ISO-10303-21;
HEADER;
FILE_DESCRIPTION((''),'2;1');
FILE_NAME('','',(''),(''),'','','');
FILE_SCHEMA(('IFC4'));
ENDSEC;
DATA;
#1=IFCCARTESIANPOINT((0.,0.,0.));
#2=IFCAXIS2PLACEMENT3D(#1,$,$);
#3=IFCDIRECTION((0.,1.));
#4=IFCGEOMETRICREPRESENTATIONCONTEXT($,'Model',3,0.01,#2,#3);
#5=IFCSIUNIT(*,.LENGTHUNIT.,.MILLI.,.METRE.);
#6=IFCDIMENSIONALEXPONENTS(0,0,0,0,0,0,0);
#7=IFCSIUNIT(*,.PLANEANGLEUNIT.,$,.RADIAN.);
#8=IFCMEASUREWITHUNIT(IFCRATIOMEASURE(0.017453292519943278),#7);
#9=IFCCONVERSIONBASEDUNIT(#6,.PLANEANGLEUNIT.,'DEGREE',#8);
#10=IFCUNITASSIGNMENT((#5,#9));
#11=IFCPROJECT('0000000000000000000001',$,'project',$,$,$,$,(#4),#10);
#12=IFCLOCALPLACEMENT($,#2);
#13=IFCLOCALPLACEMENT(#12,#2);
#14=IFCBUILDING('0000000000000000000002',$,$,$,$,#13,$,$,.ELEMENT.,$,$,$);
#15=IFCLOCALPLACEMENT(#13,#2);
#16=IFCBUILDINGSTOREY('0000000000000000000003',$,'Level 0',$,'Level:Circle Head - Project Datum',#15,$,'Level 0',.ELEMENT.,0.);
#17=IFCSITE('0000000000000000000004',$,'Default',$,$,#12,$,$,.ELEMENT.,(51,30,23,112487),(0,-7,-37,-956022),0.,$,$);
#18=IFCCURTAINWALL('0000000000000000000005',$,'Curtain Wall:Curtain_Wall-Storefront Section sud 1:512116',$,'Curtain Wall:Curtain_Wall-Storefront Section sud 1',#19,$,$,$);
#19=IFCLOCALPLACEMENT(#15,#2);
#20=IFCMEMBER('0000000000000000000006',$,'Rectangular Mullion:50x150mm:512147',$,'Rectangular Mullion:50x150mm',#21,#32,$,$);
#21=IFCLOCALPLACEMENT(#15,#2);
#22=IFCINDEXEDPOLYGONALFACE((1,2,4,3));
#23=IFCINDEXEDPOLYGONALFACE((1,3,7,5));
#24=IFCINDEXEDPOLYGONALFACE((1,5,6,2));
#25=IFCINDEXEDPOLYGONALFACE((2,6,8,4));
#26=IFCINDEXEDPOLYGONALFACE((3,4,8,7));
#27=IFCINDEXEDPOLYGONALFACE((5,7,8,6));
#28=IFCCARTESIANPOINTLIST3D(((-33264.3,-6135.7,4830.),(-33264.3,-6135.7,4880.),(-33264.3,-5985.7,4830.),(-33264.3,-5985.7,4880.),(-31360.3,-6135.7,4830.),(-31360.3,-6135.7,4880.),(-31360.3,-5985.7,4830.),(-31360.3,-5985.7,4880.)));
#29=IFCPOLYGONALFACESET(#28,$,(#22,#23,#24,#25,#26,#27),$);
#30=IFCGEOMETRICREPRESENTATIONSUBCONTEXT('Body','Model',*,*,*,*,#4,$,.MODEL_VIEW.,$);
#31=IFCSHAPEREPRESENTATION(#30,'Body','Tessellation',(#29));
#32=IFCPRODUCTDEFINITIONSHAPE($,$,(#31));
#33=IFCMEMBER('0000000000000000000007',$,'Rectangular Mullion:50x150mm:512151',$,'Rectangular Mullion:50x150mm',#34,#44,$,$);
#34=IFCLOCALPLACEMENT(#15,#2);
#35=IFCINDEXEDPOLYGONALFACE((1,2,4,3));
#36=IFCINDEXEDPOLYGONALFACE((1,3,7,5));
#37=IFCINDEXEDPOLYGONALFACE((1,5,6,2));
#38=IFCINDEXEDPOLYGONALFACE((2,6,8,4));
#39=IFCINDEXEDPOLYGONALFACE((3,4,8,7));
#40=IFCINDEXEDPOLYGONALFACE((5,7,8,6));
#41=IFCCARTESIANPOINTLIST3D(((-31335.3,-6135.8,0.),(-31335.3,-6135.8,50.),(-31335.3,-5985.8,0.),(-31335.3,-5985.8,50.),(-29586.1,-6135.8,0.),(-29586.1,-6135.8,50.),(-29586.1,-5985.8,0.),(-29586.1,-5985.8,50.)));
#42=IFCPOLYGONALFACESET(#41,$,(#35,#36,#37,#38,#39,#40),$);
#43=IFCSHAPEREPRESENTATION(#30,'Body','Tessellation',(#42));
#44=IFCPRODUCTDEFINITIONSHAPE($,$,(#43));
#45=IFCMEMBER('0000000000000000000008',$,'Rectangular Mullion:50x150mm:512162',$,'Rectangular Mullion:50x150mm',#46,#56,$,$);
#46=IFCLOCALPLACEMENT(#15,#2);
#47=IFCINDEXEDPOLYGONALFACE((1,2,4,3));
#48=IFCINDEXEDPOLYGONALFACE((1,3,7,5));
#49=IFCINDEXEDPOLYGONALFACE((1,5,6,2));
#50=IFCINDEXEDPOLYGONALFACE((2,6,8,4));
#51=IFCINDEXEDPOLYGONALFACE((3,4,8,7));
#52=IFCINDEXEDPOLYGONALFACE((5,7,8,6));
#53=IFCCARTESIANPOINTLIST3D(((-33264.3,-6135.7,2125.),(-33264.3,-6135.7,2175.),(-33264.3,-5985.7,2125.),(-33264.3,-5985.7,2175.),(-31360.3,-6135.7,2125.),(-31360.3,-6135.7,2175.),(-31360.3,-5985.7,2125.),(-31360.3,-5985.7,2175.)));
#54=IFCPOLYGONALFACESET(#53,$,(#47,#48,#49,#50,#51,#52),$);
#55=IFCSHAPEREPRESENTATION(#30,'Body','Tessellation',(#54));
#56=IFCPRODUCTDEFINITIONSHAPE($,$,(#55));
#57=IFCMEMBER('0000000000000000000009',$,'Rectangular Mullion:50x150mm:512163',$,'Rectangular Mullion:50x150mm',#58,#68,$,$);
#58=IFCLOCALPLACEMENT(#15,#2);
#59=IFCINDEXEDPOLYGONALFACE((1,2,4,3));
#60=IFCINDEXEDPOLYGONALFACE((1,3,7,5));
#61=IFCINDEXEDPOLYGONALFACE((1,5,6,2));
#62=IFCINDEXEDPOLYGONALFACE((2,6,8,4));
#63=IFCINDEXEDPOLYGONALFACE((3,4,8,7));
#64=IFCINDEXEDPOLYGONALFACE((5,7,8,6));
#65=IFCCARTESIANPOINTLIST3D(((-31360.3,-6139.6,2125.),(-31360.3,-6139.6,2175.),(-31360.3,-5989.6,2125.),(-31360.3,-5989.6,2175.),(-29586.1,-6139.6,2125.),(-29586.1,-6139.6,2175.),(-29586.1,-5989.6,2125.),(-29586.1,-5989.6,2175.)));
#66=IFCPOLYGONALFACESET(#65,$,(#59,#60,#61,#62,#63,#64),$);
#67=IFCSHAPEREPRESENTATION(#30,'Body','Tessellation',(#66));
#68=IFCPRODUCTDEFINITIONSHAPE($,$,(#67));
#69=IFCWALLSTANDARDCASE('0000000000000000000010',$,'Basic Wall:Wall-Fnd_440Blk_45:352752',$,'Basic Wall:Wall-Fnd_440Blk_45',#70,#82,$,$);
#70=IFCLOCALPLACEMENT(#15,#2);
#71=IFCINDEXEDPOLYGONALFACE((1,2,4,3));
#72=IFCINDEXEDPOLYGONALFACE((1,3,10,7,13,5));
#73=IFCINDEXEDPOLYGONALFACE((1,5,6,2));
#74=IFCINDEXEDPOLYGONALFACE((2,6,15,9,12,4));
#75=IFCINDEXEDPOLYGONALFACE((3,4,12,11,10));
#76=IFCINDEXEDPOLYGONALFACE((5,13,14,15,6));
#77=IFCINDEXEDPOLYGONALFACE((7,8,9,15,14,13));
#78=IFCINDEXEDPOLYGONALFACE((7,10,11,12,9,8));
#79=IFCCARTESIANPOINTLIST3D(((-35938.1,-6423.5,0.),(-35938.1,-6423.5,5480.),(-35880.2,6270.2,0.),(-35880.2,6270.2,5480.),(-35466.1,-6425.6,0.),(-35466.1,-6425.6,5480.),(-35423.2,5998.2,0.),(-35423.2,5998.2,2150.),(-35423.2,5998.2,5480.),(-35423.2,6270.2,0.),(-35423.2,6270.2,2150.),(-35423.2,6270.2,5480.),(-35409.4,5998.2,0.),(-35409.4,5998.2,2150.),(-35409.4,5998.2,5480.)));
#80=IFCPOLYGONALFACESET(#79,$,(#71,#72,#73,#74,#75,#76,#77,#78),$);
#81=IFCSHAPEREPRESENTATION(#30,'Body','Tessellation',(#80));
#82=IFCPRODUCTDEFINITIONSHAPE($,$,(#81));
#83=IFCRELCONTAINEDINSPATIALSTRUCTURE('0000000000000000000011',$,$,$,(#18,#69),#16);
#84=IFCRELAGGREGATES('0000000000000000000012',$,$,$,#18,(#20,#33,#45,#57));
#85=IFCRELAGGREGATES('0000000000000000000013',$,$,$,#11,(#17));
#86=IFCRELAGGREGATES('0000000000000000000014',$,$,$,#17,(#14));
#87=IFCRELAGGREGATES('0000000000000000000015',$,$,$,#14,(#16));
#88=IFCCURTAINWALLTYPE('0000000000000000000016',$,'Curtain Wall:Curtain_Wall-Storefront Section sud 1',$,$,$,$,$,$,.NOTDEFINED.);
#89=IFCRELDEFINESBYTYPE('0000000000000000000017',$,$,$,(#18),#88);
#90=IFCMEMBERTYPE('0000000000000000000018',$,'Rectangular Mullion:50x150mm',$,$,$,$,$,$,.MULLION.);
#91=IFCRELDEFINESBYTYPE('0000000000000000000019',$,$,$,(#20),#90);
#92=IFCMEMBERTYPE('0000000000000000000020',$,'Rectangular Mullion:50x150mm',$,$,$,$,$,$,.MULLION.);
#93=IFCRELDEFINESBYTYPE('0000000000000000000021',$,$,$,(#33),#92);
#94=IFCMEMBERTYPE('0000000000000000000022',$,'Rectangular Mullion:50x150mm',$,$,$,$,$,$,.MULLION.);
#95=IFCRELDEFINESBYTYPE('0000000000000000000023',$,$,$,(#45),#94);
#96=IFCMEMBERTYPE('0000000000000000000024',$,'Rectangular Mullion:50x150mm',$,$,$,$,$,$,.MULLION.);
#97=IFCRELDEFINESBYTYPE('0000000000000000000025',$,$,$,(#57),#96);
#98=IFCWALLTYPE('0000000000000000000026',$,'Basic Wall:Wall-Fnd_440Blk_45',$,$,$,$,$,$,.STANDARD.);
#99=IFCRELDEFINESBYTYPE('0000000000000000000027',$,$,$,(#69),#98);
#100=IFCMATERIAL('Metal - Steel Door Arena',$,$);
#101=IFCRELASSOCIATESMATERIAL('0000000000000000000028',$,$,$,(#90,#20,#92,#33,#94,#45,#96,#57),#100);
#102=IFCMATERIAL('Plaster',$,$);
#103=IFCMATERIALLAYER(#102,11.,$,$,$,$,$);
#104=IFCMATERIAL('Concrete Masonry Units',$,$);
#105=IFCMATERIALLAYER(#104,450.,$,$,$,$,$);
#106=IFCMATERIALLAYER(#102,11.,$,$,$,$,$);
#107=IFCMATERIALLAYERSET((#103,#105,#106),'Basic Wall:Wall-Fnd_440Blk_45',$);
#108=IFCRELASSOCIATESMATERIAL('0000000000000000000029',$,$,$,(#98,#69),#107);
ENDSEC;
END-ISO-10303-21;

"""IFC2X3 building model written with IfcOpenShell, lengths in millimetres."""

from ifc_helpers import new_model, entity, si_unit, converted_unit, direction, frame, frame_2d, origin, origin_2d_with_axis, place, context, subcontext, project, spatial, polyline, rectangle, outline, extrude, source, transform, mapped, material, layer, layer_set, layer_usage, type_object, type_shapes, element, aggregate, save


model = new_model("IFC2X3")

# Units and contexts
model_context = context("Model", 3, precision=0.01, world=origin(), true_north=direction((0.0, 1.0)))
body_context = subcontext(model_context, "Body", "Model", "MODEL_VIEW")
ifc_project = project(units=[si_unit("LENGTHUNIT", "METRE", prefix="MILLI"), converted_unit("PLANEANGLEUNIT", "DEGREE", entity("IfcRatioMeasure", 0.017453292519943278), si_unit("PLANEANGLEUNIT", "RADIAN"), dimensions=[0, 0, 0, 0, 0, 0, 0])], contexts=[model_context])

# Site, building, storey
site_placement = place(None, origin())
site = spatial("IfcSite", under=ifc_project, at=site_placement, Name="Default", CompositionType="ELEMENT", RefLatitude=(51, 30, 23, 112487), RefLongitude=(0, -7, -37, -956022), RefElevation=0.0)
building_placement = place(site_placement, origin())
building = spatial("IfcBuilding", under=site, at=building_placement, CompositionType="ELEMENT")
storey_placement = place(building_placement, origin())
storey = spatial("IfcBuildingStorey", under=building, at=storey_placement, Name="Level 0", ObjectType="Level:Circle Head - Project Datum", LongName="Level 0", CompositionType="ELEMENT", Elevation=0.0)

# Curtain wall, members
curtain_wall_type = type_object("IfcCurtainWallType", Name="Curtain Wall:Curtain_Wall-Storefront Section sud 1", PredefinedType="NOTDEFINED")
curtain_wall_placement = place(storey_placement, origin())
curtain_wall = element("IfcCurtainWall", 1, at=curtain_wall_placement, inside=storey, type_object=curtain_wall_type, Name="Curtain Wall:Curtain_Wall-Storefront Section sud 1:512116", ObjectType="Curtain Wall:Curtain_Wall-Storefront Section sud 1")
ifc_material_1 = material(Name="Metal - Steel Door Arena")
member_type_1 = type_object("IfcMemberType", Name="Rectangular Mullion:50x150mm", PredefinedType="MULLION", material=ifc_material_1)
shared_shape_1 = source(origin(), body_context, "Body", "SweptSolid", [
    extrude(rectangle(XDim=150.0, YDim=50.0, at=origin_2d_with_axis()), frame((-25.0, 0.0, -1904.0), z_axis=(0.0, 0.0, 1.0), x_axis=(0.0, -1.0, 0.0)), (0.0, 0.0, 1.0), 1904.0),
])
type_shapes(member_type_1, [shared_shape_1])
member_1_placement = place(curtain_wall_placement, frame((-31360.3, -6060.7, 4880.0), z_axis=(1.0, 0.0, 0.0), x_axis=(0.0, 0.0, 1.0)))
member_1 = element("IfcMember", 2, at=member_1_placement, type_object=member_type_1, material=ifc_material_1, Name="Rectangular Mullion:50x150mm:512147", ObjectType="Rectangular Mullion:50x150mm", context=body_context, shape_type="MappedRepresentation", body=[
    mapped(shared_shape_1, transform((0.0, 0.0, 0.0), scale=1.0)),
])
member_type_2 = type_object("IfcMemberType", Name="Rectangular Mullion:50x150mm", PredefinedType="MULLION", material=ifc_material_1)
shared_shape_2 = source(origin(), body_context, "Body", "SweptSolid", [
    extrude(rectangle(XDim=150.0, YDim=50.0, at=origin_2d_with_axis()), frame((-25.0, 0.0, -1749.2), z_axis=(0.0, 0.0, 1.0), x_axis=(0.0, -1.0, 0.0)), (0.0, 0.0, 1.0), 1749.2),
])
type_shapes(member_type_2, [shared_shape_2])
member_2_placement = place(curtain_wall_placement, frame((-31335.3, -6060.8, 0.0), z_axis=(-1.0, 0.0, 0.0), x_axis=(0.0, 0.0, -1.0)))
member_2 = element("IfcMember", 3, at=member_2_placement, type_object=member_type_2, material=ifc_material_1, Name="Rectangular Mullion:50x150mm:512151", ObjectType="Rectangular Mullion:50x150mm", context=body_context, shape_type="MappedRepresentation", body=[
    mapped(shared_shape_2, transform((0.0, 0.0, 0.0), scale=1.0)),
])
member_type_3 = type_object("IfcMemberType", Name="Rectangular Mullion:50x150mm", PredefinedType="MULLION", material=ifc_material_1)
shared_shape_3 = source(origin(), body_context, "Body", "SweptSolid", [
    extrude(rectangle(XDim=150.0, YDim=50.0, at=origin_2d_with_axis()), frame((0.0, 0.0, -1904.0), z_axis=(0.0, 0.0, 1.0), x_axis=(0.0, -1.0, 0.0)), (0.0, 0.0, 1.0), 1904.0),
])
type_shapes(member_type_3, [shared_shape_3])
member_3_placement = place(curtain_wall_placement, frame((-31360.3, -6060.7, 2150.0), z_axis=(1.0, 0.0, 0.0), x_axis=(0.0, 0.0, 1.0)))
member_3 = element("IfcMember", 4, at=member_3_placement, type_object=member_type_3, material=ifc_material_1, Name="Rectangular Mullion:50x150mm:512162", ObjectType="Rectangular Mullion:50x150mm", context=body_context, shape_type="MappedRepresentation", body=[
    mapped(shared_shape_3, transform((0.0, 0.0, 0.0), scale=1.0)),
])
member_type_4 = type_object("IfcMemberType", Name="Rectangular Mullion:50x150mm", PredefinedType="MULLION", material=ifc_material_1)
shared_shape_4 = source(origin(), body_context, "Body", "SweptSolid", [
    extrude(rectangle(XDim=150.0, YDim=50.0, at=origin_2d_with_axis()), frame((0.0, 0.0, -1774.2), z_axis=(0.0, 0.0, 1.0), x_axis=(0.0, -1.0, 0.0)), (0.0, 0.0, 1.0), 1774.2),
])
type_shapes(member_type_4, [shared_shape_4])
member_4_placement = place(curtain_wall_placement, frame((-29586.1, -6064.6, 2150.0), z_axis=(1.0, 0.0, 0.0), x_axis=(0.0, 0.0, 1.0)))
member_4 = element("IfcMember", 5, at=member_4_placement, type_object=member_type_4, material=ifc_material_1, Name="Rectangular Mullion:50x150mm:512163", ObjectType="Rectangular Mullion:50x150mm", context=body_context, shape_type="MappedRepresentation", body=[
    mapped(shared_shape_4, transform((0.0, 0.0, 0.0), scale=1.0)),
])
aggregate(curtain_wall, [member_1, member_2, member_3, member_4])

# Wall, opening
ifc_material_2 = material(Name="Plaster")
ifc_layer_1 = layer(ifc_material_2, 11.0)
ifc_material_3 = material(Name="Concrete Masonry Units")
ifc_layer_2 = layer(ifc_material_3, 450.0)
ifc_layer_3 = layer(ifc_material_2, 11.0)
ifc_layer_set = layer_set([ifc_layer_1, ifc_layer_2, ifc_layer_3], Name="Basic Wall:Wall-Fnd_440Blk_45")
ifc_layer_usage = layer_usage(ifc_layer_set, "AXIS2", "NEGATIVE", 236.0)
wall_type = type_object("IfcWallType", Name="Basic Wall:Wall-Fnd_440Blk_45", PredefinedType="STANDARD", material=ifc_layer_set)
wall_placement = place(storey_placement, frame((-35644.2, 6271.3, 0.0), z_axis=(0.0, 0.0, 1.0), x_axis=(-0.004561, -0.99999, 0.0)))
wall = element("IfcWallStandardCase", 6, at=wall_placement, inside=storey, type_object=wall_type, material=ifc_layer_usage, Name="Basic Wall:Wall-Fnd_440Blk_45:352752", ObjectType="Basic Wall:Wall-Fnd_440Blk_45", context=body_context, shape_type="SweptSolid", body=[
    extrude(outline(polyline([(12696.0, -236.0), (12696.0, 236.0), (12611.6, 236.0), (12247.1, 236.0), (272.0, 236.0), (272.1, 222.2), (0.1, 221.0), (2.2, -236.0), (12696.0, -236.0)])), origin(), (0.0, 0.0, 1.0), 5480.0),
])
opening_placement = place(wall_placement, origin())
element("IfcOpeningElement", 7, at=opening_placement, cuts=wall, ObjectType="Opening", context=body_context, shape_type="SweptSolid", body=[
    extrude(rectangle(XDim=2150.0, YDim=272.0, at=frame_2d((0.0, 0.0), x_axis=(0.0, 1.0))), frame((136.1, 221.6, 1075.0), z_axis=(-0.004561, 0.99999, 0.0), x_axis=(-0.99999, -0.004561, 0.0)), (0.0, 0.0, 1.0), 1600.0),
])

save(model, "model.ifc")
